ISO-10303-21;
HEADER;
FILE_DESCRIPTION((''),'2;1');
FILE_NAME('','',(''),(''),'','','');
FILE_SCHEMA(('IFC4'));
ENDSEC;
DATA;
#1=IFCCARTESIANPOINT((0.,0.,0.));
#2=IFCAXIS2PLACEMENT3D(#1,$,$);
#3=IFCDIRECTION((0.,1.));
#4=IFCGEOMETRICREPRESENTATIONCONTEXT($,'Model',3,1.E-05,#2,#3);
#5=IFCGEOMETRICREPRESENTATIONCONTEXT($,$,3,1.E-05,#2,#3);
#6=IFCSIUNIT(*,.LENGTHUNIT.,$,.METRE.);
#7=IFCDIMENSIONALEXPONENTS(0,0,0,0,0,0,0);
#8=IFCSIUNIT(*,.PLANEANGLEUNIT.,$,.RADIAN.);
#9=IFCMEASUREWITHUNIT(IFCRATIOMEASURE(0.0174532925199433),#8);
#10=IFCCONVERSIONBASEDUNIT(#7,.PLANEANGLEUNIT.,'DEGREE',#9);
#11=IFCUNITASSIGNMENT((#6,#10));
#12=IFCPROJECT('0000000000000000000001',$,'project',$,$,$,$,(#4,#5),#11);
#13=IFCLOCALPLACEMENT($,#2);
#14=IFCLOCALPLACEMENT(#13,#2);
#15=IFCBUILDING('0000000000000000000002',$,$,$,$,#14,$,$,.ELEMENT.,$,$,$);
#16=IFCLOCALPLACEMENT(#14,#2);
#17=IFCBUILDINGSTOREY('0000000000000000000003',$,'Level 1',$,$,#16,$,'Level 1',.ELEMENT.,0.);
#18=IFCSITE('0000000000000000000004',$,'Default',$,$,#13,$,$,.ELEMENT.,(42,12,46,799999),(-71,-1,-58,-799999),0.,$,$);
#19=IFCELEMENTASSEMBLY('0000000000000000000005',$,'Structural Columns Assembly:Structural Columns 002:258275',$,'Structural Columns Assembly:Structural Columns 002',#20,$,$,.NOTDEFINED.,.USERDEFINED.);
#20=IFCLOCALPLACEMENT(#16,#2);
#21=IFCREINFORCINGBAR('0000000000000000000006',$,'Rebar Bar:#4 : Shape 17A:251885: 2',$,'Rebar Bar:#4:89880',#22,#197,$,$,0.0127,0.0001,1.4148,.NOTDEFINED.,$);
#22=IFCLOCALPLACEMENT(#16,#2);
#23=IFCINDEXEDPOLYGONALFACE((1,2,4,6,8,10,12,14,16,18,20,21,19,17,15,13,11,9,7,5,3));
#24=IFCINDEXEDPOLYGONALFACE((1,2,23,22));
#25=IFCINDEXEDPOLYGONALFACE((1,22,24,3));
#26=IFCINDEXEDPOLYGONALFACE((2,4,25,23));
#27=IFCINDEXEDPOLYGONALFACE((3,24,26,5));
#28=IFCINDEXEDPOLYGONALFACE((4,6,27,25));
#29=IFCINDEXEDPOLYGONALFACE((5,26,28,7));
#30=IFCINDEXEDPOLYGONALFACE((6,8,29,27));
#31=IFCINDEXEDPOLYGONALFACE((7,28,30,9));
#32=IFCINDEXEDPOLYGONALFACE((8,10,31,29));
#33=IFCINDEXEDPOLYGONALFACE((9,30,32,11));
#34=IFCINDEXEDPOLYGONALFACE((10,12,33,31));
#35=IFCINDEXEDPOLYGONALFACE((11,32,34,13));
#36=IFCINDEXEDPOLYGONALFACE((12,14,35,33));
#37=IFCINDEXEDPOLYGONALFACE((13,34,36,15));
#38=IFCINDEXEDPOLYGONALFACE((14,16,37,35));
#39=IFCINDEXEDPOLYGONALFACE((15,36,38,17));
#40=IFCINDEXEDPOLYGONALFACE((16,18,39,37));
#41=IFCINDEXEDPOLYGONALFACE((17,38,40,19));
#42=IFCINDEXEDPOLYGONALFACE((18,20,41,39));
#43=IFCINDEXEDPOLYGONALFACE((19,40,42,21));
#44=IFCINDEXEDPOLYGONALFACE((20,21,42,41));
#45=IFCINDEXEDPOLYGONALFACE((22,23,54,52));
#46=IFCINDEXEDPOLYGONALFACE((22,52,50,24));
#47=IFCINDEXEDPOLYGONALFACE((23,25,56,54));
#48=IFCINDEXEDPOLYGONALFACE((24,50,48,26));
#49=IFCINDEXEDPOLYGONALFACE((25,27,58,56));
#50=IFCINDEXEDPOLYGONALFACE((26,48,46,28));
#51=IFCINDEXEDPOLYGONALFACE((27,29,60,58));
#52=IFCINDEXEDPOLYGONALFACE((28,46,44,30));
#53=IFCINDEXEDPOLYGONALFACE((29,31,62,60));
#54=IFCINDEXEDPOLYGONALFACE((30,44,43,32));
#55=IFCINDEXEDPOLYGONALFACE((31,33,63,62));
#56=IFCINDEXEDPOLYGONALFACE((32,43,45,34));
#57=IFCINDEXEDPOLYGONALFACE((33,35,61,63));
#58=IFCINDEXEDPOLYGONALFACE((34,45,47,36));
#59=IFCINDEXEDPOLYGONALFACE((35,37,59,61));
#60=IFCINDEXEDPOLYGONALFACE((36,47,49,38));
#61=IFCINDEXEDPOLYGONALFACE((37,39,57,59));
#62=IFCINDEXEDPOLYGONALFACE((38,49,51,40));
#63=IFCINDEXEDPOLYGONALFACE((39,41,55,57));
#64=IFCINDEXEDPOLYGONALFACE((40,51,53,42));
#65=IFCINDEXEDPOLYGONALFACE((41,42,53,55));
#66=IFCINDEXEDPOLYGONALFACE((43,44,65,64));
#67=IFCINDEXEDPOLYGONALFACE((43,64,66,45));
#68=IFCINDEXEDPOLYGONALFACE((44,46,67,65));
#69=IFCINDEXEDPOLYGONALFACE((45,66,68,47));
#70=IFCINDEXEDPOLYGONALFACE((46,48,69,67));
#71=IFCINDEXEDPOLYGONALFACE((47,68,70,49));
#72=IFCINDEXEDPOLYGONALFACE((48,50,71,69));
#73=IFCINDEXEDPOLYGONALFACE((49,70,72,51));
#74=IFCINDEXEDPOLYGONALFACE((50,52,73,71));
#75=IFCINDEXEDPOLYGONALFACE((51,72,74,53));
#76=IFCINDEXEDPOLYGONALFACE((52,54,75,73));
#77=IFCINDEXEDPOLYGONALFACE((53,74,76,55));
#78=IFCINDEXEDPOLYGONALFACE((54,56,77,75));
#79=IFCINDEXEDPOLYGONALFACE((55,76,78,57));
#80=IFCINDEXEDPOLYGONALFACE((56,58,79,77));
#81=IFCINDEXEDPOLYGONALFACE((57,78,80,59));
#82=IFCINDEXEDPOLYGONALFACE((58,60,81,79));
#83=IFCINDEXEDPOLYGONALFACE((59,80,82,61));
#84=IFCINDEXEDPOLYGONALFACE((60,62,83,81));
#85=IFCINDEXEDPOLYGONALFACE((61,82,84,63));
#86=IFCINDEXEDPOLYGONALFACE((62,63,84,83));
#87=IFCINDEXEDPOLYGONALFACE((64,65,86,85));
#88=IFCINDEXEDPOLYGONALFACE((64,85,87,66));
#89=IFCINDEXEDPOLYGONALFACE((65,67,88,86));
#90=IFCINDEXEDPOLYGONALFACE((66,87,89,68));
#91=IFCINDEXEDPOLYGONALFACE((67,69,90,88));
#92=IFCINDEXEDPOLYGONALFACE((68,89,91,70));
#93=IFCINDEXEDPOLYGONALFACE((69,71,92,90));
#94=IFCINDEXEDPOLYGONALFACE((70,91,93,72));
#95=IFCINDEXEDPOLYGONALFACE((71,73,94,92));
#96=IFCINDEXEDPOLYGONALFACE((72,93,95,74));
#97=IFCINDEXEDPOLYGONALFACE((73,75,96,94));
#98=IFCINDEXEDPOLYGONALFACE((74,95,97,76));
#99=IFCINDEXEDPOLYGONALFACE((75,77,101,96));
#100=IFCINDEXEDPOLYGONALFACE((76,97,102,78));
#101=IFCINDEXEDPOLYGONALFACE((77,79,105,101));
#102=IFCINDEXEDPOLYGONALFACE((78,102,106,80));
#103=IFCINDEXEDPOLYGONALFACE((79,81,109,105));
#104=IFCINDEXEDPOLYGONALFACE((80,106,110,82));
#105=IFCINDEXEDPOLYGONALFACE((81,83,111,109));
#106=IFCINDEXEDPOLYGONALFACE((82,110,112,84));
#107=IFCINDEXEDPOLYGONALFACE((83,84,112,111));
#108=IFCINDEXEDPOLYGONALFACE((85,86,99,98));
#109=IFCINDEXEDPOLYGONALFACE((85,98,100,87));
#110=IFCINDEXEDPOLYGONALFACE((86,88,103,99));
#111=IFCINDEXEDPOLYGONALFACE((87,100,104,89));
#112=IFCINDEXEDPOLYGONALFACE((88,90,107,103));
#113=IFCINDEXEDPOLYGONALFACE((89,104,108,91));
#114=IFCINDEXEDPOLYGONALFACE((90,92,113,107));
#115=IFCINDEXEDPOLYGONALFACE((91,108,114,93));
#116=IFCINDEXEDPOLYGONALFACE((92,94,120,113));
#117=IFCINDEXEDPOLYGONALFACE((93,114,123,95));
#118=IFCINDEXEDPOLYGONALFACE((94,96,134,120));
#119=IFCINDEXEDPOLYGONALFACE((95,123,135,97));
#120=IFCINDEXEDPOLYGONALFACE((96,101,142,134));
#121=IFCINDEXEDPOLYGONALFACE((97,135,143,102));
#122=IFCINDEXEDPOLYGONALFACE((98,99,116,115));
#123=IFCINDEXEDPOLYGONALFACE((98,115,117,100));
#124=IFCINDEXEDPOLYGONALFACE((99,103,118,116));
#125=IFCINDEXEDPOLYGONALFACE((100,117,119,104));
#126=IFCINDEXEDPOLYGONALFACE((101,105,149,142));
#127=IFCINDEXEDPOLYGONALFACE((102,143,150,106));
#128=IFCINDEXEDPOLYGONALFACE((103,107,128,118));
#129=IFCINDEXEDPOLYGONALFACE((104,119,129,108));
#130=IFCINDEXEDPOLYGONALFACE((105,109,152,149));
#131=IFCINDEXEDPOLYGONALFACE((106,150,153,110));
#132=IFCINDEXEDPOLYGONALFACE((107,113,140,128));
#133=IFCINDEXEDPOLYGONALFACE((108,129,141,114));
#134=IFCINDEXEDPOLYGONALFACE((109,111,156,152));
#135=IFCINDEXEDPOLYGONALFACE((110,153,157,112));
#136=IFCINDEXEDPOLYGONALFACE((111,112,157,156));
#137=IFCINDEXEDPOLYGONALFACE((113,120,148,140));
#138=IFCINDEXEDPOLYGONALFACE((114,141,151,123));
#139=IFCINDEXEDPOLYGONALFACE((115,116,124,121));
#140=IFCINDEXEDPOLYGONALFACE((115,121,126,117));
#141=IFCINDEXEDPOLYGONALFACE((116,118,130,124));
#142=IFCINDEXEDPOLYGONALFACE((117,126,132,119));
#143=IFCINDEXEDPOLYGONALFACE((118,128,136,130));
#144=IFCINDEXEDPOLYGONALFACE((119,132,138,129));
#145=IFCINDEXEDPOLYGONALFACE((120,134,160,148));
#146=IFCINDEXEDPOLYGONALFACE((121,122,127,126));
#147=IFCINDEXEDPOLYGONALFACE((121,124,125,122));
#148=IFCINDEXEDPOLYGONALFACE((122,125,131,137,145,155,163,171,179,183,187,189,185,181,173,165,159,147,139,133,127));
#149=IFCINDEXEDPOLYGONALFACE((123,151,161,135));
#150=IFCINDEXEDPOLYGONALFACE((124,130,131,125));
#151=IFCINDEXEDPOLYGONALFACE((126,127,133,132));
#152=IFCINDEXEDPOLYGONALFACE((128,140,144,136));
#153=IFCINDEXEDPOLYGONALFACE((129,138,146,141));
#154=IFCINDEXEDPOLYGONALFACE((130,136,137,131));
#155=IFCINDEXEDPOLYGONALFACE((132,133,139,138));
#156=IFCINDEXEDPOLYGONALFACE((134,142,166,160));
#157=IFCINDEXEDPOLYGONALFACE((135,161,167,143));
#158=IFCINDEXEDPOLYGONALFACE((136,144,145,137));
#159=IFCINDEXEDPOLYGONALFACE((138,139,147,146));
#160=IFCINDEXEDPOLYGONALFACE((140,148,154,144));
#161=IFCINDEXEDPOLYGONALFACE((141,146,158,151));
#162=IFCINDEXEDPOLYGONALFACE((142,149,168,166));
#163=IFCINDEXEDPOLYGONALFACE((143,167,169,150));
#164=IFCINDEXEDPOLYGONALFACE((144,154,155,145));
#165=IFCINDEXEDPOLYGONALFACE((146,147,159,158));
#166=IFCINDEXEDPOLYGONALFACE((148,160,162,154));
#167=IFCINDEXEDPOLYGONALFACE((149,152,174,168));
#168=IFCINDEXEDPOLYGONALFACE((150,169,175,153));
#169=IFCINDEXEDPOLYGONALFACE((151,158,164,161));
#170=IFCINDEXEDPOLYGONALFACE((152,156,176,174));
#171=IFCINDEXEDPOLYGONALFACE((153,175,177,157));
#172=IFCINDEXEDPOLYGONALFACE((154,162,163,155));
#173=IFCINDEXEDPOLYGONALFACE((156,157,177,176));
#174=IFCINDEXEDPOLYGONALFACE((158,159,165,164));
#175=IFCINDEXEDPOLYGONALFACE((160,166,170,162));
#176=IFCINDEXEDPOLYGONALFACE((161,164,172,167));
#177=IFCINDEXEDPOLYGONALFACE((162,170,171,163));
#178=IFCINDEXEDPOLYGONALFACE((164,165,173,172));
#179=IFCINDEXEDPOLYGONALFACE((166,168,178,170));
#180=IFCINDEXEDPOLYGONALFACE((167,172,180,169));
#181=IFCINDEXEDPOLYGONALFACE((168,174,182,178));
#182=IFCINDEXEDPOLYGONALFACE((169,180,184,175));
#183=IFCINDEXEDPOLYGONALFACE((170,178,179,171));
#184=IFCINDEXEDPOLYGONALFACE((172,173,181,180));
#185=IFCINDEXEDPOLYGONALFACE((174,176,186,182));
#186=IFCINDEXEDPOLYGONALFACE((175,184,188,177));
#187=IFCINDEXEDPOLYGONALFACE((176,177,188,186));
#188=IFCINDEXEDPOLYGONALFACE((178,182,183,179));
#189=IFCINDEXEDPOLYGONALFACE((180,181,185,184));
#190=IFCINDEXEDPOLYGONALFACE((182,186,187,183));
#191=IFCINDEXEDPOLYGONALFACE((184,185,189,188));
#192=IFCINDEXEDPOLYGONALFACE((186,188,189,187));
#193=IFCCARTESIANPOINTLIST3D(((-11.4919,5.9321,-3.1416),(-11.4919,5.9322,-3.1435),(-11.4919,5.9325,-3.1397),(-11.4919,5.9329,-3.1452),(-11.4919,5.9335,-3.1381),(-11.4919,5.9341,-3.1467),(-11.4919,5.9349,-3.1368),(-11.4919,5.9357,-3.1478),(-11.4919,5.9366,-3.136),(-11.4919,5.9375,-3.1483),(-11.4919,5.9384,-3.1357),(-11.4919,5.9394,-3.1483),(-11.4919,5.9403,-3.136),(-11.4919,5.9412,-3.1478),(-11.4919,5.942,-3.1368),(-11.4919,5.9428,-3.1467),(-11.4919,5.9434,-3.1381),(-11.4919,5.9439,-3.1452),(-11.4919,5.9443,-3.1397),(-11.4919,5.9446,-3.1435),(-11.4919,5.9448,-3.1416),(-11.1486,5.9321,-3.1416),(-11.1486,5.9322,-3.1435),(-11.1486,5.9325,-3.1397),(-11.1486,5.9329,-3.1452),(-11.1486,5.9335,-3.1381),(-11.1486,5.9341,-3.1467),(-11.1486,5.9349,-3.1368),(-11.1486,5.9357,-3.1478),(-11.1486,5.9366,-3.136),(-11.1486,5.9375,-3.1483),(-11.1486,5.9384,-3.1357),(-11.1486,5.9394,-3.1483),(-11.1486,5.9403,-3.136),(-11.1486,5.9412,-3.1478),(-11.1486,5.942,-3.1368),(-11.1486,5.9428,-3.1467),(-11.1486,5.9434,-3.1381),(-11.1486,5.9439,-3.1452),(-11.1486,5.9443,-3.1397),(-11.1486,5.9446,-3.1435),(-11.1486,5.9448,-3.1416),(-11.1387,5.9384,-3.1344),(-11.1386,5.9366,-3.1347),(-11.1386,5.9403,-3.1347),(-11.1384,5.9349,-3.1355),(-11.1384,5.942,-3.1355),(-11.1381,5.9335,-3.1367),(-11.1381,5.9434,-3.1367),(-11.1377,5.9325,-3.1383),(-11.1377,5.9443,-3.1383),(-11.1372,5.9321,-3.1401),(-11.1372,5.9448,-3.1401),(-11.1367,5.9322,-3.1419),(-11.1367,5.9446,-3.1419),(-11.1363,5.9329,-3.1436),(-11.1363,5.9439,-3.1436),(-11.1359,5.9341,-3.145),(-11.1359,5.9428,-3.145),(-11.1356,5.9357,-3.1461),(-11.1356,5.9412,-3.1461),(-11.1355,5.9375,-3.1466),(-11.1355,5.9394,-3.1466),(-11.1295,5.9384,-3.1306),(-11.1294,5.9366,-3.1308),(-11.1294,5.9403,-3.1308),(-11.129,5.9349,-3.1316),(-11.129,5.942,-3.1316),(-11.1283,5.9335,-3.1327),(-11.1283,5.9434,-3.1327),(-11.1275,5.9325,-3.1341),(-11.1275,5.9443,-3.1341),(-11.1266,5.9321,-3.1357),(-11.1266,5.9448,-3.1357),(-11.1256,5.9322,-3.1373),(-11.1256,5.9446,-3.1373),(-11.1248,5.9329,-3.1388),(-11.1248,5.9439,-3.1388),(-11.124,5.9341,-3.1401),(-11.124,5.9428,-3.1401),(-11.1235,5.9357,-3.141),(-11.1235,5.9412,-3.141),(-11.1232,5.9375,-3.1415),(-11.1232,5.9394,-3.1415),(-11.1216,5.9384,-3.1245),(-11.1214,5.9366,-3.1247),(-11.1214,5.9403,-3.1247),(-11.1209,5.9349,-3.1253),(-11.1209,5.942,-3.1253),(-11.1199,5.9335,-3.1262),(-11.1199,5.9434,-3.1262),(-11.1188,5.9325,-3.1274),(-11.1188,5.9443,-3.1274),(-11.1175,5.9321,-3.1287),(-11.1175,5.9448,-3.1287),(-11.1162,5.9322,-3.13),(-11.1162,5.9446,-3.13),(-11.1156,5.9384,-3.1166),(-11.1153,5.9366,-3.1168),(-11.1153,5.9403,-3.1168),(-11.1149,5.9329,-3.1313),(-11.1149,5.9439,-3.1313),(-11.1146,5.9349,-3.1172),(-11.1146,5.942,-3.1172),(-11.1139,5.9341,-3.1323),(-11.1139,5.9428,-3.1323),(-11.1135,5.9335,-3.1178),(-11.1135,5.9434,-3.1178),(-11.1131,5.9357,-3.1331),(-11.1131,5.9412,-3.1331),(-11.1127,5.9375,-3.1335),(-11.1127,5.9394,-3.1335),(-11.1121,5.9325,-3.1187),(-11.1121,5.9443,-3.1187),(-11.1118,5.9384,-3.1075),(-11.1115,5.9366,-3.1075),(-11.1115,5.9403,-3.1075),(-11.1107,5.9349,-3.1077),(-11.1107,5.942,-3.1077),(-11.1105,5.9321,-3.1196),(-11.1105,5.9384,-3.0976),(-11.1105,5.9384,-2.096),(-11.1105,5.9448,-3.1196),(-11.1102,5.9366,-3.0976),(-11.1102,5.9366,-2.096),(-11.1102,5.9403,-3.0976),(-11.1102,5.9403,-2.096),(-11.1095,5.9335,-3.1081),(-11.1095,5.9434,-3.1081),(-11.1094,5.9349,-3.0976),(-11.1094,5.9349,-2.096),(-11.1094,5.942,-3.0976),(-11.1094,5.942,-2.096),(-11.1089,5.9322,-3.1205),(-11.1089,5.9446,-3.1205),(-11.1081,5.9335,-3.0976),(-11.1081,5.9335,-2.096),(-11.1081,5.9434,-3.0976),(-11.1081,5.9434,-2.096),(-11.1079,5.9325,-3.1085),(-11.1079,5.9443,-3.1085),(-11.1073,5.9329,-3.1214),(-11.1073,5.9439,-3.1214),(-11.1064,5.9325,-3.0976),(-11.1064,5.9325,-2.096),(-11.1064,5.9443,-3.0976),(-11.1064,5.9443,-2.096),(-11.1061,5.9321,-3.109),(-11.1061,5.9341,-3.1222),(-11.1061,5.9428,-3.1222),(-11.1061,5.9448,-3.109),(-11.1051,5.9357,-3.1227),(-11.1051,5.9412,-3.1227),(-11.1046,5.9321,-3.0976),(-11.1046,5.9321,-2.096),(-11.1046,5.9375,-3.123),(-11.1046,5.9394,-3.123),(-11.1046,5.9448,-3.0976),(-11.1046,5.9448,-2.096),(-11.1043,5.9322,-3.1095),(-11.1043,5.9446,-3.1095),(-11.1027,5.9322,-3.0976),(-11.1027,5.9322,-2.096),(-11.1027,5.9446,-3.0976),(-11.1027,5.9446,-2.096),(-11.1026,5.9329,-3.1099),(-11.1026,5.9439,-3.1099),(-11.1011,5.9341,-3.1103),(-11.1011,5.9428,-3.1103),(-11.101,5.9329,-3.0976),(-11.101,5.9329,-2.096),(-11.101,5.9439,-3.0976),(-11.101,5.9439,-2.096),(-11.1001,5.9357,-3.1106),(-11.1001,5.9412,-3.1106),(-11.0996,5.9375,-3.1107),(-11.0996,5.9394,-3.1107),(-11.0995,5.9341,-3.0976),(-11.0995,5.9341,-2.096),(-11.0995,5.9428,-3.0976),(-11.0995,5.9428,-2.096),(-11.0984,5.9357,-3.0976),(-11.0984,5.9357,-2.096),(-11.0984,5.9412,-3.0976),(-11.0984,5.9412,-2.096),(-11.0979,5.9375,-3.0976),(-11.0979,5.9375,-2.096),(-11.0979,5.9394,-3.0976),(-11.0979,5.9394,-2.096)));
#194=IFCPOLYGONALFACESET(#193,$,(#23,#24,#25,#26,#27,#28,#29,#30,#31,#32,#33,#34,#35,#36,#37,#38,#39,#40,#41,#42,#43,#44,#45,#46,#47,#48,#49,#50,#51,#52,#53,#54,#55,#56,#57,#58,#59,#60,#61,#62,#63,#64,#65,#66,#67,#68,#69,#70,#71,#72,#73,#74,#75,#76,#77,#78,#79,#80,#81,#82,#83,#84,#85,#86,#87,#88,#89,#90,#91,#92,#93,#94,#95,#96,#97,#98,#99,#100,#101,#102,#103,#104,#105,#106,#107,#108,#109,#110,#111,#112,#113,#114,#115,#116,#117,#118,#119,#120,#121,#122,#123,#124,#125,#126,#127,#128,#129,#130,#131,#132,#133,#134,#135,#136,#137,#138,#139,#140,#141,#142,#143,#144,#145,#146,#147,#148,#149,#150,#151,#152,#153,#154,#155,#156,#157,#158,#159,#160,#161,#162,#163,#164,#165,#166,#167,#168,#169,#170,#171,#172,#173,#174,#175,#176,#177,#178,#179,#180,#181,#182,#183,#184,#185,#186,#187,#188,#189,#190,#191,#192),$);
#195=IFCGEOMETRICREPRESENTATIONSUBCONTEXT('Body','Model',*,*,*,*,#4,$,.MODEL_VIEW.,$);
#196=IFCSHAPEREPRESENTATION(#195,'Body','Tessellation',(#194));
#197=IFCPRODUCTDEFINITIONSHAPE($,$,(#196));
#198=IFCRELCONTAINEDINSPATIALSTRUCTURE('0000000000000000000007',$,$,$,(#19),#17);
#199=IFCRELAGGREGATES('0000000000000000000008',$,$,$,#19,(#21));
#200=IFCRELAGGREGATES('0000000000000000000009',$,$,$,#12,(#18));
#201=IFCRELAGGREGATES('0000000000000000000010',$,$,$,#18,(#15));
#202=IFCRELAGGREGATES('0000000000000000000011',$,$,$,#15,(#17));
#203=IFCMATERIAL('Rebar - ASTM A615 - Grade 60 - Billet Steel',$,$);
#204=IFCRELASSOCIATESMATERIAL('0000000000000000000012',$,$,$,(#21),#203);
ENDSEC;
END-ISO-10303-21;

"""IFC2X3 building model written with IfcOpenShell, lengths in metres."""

from ifc_helpers import new_model, entity, si_unit, converted_unit, direction, origin, place, context, subcontext, project, spatial, material, element, aggregate, save


model = new_model("IFC2X3")

# Units and contexts
model_context = context("Model", 3, precision=1e-05, world=origin(), true_north=direction((0.0, 1.0)))
context_of_model = context(None, 3, precision=1e-05, world=origin(), true_north=direction((0.0, 1.0)))
body_context = subcontext(model_context, "Body", "Model", "MODEL_VIEW")
ifc_project = project(units=[si_unit("LENGTHUNIT", "METRE"), converted_unit("PLANEANGLEUNIT", "DEGREE", entity("IfcRatioMeasure", 0.0174532925199433), si_unit("PLANEANGLEUNIT", "RADIAN"), dimensions=[0, 0, 0, 0, 0, 0, 0])], contexts=[model_context, context_of_model])

# Site, building, storey
site_placement = place(None, origin())
site = spatial("IfcSite", under=ifc_project, at=site_placement, Name="Default", CompositionType="ELEMENT", RefLatitude=(42, 12, 46, 799999), RefLongitude=(-71, -1, -58, -799999), RefElevation=0.0)
building_placement = place(site_placement, origin())
building = spatial("IfcBuilding", under=site, at=building_placement, CompositionType="ELEMENT")
storey_placement = place(building_placement, origin())
storey = spatial("IfcBuildingStorey", under=building, at=storey_placement, Name="Level 1", LongName="Level 1", CompositionType="ELEMENT", Elevation=0.0)

# Element assembly, reinforcing bar
assembly_1_placement = place(storey_placement, origin())
assembly_1 = element("IfcElementAssembly", 1, at=assembly_1_placement, inside=storey, Name="Structural Columns Assembly:Structural Columns 002:258275", ObjectType="Structural Columns Assembly:Structural Columns 002", AssemblyPlace="NOTDEFINED", PredefinedType="USERDEFINED")
ifc_material_1 = material(Name="Rebar - ASTM A615 - Grade 60 - Billet Steel")
reinforcing_bar_1_placement = place(assembly_1_placement, origin())
reinforcing_bar_1 = element("IfcReinforcingBar", 2, at=reinforcing_bar_1_placement, material=ifc_material_1, Name="Rebar Bar:#4 : Shape 17A:251885: 2", ObjectType="Rebar Bar:#4:89880", BarLength=1.4148, BarRole="NOTDEFINED", CrossSectionArea=0.0001, NominalDiameter=0.0127, context=body_context, shape_type="AdvancedSweptSolid", body=[
    entity("IfcSweptDiskSolid", entity("IfcCompositeCurve", [entity("IfcCompositeCurveSegment", "CONTINUOUS", True, entity("IfcPolyline", [entity("IfcCartesianPoint", [-11.4919, 5.9384, -3.142]), entity("IfcCartesianPoint", [-11.1486, 5.9384, -3.142])])), entity("IfcCompositeCurveSegment", "CONTINUOUS", True, entity("IfcTrimmedCurve", entity("IfcCircle", entity("IfcAxis2Placement3D", entity("IfcCartesianPoint", [-11.1486, 5.9384, -3.0976]), entity("IfcDirection", [0.0, -1.0, 0.0]), entity("IfcDirection", [1.0, 0.0, 0.0])), 0.0445), [entity("IfcParameterValue", 270.0)], [entity("IfcParameterValue", 360.0)], True, "PARAMETER")), entity("IfcCompositeCurveSegment", "CONTINUOUS", True, entity("IfcPolyline", [entity("IfcCartesianPoint", [-11.1041, 5.9384, -3.0976]), entity("IfcCartesianPoint", [-11.1041, 5.9384, -2.096])]))], False), 0.0063, None, 0.0, 92.0),
])
aggregate(assembly_1, [reinforcing_bar_1])

save(model, "model.ifc")
